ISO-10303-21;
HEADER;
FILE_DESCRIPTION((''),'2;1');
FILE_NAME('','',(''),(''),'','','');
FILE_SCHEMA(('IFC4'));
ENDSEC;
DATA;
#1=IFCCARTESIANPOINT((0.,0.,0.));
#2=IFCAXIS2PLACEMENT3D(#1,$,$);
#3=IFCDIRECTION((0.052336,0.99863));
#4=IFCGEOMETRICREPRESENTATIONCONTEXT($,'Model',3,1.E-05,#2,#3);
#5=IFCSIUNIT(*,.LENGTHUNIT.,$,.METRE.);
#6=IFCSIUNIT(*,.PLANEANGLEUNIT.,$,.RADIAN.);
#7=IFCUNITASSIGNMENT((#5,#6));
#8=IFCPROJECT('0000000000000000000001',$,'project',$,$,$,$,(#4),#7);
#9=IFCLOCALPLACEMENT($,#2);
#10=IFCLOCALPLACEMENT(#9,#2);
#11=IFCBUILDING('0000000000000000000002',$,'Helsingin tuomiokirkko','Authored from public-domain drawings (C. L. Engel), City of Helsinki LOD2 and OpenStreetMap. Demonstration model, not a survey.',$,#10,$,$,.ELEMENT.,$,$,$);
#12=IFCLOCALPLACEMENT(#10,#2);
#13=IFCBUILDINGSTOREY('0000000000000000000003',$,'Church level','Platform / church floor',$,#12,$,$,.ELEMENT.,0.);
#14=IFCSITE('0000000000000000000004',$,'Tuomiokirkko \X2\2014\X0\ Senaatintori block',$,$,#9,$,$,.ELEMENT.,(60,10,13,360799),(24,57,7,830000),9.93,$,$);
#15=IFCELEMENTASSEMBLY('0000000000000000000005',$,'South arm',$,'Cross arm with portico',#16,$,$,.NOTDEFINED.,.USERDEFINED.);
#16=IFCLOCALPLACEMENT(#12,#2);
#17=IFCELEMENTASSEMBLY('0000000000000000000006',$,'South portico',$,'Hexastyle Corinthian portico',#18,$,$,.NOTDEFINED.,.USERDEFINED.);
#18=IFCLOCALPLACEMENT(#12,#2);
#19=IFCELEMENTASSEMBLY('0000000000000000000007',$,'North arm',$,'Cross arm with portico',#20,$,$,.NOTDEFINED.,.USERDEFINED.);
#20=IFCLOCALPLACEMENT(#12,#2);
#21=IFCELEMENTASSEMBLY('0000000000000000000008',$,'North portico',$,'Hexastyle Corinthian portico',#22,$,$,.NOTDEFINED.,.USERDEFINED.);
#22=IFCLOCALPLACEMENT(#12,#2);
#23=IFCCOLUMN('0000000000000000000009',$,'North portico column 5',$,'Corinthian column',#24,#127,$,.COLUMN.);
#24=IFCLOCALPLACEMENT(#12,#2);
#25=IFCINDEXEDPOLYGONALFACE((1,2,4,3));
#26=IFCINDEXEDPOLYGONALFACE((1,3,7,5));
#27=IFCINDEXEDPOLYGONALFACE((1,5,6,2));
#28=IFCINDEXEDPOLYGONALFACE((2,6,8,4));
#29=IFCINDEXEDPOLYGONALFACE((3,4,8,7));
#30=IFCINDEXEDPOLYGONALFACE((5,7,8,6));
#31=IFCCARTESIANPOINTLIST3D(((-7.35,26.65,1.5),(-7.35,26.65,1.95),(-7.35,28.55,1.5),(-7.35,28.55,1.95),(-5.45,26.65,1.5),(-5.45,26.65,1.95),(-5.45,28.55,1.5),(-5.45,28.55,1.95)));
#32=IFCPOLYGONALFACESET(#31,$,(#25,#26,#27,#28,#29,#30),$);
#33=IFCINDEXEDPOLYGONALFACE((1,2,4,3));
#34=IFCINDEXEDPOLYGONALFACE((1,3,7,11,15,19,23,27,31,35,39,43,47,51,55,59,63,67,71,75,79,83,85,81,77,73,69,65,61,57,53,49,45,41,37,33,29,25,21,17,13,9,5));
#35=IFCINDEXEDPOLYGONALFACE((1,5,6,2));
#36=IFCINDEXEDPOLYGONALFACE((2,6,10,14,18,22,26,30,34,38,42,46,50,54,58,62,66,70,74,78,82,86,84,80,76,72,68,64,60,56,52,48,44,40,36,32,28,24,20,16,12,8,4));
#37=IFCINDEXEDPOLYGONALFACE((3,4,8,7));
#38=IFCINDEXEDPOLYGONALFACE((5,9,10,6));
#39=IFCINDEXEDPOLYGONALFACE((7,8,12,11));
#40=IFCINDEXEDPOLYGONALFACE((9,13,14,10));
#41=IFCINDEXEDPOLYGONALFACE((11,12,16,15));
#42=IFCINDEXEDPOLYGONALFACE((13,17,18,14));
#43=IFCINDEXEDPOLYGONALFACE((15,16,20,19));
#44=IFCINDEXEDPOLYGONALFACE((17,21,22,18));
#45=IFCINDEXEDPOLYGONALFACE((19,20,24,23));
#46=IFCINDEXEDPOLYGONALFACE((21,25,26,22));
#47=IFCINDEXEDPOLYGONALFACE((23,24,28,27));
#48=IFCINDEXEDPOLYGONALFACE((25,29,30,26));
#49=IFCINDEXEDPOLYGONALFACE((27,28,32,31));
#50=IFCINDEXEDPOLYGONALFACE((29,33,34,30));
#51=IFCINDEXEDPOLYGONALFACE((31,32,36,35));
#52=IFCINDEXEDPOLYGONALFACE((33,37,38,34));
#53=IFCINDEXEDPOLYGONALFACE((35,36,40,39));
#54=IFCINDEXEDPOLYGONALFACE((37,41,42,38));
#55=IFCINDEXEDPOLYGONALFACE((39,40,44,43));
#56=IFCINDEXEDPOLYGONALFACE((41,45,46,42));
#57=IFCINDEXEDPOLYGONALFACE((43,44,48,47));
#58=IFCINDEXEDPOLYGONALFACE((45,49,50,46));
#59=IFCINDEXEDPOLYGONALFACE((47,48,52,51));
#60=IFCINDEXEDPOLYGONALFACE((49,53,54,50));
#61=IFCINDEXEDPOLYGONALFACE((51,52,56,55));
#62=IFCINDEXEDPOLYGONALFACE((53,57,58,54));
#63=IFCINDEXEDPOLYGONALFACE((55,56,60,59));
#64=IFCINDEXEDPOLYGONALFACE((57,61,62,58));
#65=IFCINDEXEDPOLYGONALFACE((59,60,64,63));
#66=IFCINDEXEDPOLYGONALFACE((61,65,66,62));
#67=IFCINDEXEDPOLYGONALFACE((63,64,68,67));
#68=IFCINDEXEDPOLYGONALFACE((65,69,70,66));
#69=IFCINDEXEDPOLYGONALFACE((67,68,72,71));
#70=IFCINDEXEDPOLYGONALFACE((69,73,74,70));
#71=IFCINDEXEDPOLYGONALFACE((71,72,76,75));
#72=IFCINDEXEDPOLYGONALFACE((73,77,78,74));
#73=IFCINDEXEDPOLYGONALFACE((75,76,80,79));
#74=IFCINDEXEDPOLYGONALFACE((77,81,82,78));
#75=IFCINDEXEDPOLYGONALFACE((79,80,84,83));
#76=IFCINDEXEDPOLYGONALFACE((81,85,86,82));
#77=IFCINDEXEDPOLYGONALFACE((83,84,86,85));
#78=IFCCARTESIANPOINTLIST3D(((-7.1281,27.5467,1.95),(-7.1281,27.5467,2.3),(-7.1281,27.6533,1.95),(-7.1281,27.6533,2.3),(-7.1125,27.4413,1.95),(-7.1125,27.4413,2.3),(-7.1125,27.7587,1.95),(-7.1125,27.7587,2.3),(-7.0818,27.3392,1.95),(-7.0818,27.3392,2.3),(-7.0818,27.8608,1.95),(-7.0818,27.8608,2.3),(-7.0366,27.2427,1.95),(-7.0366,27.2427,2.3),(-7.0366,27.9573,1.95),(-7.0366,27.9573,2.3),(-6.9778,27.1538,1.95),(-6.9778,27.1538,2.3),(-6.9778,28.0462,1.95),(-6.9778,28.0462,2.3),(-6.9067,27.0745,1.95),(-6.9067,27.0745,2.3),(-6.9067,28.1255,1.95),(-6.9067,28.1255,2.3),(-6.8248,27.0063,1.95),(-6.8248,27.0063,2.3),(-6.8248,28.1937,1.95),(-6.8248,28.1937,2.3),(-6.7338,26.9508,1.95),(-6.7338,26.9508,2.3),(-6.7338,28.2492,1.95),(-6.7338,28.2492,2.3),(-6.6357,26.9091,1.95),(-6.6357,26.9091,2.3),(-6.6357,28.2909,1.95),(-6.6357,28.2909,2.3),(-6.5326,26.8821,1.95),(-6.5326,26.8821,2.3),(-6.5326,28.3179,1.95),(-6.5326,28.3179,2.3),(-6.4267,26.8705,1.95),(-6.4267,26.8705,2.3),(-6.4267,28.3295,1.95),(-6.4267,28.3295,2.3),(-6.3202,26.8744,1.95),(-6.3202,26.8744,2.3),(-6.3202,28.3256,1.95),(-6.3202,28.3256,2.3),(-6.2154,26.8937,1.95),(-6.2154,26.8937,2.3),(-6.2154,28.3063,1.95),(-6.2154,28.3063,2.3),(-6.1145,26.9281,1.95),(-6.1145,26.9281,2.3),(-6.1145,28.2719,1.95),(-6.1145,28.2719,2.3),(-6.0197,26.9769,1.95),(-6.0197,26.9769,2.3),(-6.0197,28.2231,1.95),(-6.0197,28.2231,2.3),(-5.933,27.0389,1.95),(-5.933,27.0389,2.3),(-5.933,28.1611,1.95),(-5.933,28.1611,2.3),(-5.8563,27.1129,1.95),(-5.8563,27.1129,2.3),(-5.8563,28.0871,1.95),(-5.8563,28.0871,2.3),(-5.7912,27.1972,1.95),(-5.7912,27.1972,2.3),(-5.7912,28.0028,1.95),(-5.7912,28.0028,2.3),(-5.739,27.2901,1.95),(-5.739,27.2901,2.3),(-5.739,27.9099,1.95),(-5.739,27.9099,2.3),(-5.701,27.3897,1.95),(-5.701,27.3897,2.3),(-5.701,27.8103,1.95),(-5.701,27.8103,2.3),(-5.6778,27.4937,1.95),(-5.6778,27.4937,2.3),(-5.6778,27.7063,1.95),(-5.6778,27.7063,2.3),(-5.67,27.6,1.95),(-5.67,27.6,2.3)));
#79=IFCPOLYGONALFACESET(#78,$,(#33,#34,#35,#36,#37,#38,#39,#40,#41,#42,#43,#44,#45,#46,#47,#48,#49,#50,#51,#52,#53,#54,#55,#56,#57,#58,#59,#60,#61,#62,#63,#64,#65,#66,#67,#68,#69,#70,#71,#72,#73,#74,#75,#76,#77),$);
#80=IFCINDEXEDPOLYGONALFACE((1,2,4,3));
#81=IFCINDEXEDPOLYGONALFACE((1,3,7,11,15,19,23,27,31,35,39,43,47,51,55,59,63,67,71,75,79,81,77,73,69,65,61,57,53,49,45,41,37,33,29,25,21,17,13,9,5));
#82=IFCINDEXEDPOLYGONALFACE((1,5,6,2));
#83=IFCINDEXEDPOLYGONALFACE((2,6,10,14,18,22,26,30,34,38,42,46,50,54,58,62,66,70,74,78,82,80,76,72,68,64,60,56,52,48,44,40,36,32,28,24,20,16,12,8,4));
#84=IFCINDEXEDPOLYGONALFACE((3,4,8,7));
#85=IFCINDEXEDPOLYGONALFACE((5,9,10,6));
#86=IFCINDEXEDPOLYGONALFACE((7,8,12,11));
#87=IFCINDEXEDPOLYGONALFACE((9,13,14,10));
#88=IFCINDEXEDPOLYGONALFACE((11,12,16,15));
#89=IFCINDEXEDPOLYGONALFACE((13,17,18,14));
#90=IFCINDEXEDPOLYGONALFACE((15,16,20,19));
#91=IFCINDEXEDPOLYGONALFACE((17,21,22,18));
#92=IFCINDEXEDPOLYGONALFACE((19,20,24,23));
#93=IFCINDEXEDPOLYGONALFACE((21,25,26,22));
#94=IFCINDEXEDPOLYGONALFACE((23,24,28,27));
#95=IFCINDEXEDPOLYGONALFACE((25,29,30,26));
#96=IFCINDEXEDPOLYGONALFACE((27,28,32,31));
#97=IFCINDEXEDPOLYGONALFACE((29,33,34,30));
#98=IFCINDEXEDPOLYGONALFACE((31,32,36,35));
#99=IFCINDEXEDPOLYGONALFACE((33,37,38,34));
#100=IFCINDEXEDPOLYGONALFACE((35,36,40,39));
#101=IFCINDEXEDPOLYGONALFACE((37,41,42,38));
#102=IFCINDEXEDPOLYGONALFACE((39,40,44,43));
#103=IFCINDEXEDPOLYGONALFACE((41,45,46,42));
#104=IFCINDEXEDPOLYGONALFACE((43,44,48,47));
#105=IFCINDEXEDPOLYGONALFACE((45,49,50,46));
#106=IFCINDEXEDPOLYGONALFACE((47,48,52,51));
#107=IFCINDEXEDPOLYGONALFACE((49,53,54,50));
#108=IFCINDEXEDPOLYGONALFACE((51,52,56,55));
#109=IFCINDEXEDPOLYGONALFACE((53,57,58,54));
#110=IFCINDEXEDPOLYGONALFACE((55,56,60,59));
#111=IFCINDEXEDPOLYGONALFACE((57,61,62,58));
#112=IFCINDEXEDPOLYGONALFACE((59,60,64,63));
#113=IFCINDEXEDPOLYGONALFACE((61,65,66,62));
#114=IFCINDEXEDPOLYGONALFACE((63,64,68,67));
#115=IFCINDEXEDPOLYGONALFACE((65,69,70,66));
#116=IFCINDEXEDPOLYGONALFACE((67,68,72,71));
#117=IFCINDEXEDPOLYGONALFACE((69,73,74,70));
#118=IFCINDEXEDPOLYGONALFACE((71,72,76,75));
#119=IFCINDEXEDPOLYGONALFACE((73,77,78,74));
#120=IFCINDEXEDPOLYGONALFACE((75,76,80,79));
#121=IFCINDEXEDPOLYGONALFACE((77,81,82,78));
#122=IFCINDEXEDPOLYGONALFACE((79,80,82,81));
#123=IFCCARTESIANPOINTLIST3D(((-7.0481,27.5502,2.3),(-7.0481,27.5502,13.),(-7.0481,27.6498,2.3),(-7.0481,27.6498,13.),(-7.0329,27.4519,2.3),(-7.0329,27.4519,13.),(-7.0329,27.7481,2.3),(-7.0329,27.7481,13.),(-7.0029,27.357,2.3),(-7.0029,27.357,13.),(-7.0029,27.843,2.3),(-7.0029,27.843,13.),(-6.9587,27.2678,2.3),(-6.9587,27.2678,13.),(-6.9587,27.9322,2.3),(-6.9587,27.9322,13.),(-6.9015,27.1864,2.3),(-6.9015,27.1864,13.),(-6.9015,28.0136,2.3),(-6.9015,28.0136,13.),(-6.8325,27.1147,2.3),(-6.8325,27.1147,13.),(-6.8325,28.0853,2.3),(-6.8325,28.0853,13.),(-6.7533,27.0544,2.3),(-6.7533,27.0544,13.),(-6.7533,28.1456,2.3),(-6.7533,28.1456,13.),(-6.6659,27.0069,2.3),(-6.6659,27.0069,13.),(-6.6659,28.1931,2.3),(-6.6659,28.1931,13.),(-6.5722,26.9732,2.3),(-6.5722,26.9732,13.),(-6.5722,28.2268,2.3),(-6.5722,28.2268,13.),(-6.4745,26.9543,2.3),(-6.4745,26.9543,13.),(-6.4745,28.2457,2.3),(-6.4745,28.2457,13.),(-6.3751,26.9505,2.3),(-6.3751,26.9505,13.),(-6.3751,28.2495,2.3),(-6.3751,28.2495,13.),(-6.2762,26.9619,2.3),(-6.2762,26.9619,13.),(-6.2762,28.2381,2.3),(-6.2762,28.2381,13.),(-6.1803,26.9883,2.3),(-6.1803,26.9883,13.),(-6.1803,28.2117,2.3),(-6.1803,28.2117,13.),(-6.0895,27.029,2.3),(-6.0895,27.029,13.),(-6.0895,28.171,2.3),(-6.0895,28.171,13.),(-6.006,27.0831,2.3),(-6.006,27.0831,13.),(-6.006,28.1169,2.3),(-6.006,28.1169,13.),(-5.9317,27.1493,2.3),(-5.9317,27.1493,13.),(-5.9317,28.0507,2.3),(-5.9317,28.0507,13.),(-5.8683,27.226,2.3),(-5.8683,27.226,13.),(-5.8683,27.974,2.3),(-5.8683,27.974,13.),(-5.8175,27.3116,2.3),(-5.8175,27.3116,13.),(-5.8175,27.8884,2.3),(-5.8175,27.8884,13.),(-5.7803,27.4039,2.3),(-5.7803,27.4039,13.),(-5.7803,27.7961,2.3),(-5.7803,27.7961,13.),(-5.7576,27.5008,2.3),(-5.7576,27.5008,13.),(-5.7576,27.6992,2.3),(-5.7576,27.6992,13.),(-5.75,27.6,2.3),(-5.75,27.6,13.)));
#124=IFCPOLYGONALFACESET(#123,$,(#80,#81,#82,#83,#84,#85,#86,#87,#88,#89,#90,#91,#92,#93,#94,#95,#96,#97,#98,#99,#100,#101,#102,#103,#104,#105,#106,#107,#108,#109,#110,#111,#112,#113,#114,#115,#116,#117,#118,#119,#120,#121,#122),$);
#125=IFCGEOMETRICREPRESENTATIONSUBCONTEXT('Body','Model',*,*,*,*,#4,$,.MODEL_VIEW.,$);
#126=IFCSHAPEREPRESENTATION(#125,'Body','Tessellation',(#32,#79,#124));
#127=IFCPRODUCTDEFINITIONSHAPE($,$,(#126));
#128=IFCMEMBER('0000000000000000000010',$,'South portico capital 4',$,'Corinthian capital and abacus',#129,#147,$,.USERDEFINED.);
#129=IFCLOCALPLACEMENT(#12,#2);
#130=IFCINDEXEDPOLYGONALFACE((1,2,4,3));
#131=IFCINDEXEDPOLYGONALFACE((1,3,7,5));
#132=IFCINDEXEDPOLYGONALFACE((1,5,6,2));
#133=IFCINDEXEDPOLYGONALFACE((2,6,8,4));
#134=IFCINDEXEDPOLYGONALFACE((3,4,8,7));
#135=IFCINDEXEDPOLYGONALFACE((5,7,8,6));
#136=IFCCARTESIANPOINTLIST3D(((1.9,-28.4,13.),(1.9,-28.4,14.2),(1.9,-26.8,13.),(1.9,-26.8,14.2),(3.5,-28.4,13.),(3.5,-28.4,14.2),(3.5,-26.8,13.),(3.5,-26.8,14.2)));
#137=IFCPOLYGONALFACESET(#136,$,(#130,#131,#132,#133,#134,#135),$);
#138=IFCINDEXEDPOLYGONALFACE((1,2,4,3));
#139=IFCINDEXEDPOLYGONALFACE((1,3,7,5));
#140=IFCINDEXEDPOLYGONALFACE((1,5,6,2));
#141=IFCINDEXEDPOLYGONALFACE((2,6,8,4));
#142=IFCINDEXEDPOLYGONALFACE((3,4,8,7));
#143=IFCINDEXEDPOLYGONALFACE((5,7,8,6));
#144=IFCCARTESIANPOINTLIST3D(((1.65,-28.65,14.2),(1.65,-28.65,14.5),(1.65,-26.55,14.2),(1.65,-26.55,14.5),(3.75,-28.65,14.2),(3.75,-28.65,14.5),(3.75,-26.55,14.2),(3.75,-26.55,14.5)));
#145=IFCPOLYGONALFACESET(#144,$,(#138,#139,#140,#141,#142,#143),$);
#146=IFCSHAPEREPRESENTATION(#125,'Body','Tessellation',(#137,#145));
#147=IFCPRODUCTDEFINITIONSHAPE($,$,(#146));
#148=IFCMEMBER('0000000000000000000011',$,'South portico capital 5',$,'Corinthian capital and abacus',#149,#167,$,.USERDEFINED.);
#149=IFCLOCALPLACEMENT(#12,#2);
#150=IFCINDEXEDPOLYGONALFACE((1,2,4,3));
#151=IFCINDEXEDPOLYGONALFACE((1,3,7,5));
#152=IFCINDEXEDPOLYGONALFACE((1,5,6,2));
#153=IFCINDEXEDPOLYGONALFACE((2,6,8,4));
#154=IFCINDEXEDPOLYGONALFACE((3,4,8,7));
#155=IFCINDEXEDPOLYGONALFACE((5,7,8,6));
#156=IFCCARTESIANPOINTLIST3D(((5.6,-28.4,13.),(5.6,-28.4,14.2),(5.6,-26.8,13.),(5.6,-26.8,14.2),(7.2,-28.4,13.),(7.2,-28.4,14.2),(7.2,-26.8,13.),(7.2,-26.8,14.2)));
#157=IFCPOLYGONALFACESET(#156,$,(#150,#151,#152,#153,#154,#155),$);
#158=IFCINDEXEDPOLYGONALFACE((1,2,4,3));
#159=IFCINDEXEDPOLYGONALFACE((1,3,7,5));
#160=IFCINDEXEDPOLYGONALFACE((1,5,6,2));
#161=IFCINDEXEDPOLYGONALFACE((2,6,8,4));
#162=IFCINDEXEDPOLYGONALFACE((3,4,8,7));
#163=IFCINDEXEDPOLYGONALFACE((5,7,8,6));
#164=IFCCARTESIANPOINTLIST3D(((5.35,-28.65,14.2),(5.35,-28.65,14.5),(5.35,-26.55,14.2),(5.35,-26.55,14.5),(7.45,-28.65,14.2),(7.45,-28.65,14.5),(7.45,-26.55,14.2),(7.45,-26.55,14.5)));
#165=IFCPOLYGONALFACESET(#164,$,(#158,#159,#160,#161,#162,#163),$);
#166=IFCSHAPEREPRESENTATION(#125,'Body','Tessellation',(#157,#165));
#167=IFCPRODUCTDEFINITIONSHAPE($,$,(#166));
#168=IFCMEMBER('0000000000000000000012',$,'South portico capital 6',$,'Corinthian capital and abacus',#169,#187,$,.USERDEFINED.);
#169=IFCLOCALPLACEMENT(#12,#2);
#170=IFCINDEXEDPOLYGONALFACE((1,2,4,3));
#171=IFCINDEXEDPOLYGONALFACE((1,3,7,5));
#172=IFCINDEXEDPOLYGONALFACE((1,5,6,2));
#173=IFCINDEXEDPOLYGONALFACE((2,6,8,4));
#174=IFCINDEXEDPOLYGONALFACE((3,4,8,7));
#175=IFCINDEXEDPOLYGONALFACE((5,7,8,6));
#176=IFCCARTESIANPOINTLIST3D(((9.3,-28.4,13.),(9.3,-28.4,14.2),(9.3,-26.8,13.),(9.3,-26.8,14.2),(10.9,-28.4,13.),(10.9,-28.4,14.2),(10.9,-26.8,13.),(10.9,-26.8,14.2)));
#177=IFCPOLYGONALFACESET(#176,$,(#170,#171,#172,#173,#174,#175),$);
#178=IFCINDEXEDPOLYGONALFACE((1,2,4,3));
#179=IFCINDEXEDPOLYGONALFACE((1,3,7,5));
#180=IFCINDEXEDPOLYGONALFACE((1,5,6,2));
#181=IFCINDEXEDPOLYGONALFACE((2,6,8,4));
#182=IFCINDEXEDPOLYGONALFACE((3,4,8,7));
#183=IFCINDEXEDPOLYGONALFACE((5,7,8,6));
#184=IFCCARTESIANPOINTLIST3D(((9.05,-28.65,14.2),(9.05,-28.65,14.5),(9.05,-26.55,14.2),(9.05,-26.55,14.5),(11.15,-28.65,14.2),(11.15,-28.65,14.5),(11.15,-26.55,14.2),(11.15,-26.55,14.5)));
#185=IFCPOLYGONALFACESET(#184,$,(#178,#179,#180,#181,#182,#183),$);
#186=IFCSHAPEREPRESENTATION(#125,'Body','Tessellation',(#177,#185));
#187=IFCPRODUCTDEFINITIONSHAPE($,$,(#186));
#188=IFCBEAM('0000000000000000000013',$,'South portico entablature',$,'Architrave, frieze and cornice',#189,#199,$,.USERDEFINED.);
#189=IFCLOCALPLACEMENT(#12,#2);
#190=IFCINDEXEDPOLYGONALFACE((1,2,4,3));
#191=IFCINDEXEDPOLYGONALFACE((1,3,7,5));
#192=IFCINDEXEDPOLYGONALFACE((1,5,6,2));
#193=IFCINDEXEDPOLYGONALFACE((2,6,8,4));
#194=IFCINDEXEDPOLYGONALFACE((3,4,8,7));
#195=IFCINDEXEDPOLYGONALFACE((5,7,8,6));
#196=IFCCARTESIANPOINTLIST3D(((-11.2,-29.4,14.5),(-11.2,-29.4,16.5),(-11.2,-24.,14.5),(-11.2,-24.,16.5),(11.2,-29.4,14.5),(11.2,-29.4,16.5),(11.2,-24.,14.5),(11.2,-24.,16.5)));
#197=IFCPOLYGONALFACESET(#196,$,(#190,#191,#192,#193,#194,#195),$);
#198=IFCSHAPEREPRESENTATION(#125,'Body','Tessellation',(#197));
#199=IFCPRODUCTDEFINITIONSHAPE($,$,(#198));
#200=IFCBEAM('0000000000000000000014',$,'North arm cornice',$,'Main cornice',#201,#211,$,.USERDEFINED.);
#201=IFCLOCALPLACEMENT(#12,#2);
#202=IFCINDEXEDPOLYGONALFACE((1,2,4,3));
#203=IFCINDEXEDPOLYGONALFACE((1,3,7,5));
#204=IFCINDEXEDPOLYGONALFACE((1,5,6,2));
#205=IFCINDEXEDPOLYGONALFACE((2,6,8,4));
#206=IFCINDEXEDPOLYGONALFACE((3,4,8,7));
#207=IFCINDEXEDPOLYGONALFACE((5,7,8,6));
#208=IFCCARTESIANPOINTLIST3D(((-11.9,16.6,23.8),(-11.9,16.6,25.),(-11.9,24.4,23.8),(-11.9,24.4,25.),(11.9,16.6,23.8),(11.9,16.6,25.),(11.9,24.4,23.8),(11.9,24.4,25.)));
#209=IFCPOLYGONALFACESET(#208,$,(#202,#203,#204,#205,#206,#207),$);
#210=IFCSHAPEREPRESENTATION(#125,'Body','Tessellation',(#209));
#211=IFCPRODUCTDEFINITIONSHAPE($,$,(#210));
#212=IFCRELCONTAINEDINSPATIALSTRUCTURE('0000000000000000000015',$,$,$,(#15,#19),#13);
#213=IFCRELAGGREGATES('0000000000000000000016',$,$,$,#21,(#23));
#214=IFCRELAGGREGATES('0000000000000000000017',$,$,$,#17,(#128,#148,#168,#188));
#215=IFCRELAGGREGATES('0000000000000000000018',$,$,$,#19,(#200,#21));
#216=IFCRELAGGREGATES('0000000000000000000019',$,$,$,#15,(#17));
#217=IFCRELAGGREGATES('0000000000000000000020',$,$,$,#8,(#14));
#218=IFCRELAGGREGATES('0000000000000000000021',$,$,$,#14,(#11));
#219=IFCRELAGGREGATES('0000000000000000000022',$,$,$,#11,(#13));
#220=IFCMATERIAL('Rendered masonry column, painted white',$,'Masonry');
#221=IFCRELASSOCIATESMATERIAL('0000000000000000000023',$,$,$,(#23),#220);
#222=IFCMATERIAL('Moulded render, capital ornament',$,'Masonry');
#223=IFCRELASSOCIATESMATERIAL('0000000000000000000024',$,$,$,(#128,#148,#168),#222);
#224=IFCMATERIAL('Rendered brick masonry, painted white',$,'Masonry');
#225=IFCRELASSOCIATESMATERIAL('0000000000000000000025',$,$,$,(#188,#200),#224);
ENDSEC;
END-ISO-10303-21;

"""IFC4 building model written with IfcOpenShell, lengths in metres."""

from ifc_helpers import new_model, si_unit, direction, frame, origin, origin_2d_with_axis, place, context, subcontext, project, spatial, rectangle, circle, extrude, material, element, aggregate, save


model = new_model("IFC4")

# Units and contexts
model_context = context("Model", 3, precision=1e-05, world=origin(), true_north=direction((0.052336, 0.99863)))
body_context = subcontext(model_context, "Body", "Model", "MODEL_VIEW")
ifc_project = project(units=[si_unit("LENGTHUNIT", "METRE"), si_unit("PLANEANGLEUNIT", "RADIAN")], contexts=[model_context])

# Site, building, storey
site_placement = place(None, origin())
site = spatial("IfcSite", under=ifc_project, at=site_placement, Name="Tuomiokirkko — Senaatintori block", CompositionType="ELEMENT", RefLatitude=(60, 10, 13, 360799), RefLongitude=(24, 57, 7, 830000), RefElevation=9.93)
building_placement = place(site_placement, origin())
building = spatial("IfcBuilding", under=site, at=building_placement, Name="Helsingin tuomiokirkko", Description="Authored from public-domain drawings (C. L. Engel), City of Helsinki LOD2 and OpenStreetMap. Demonstration model, not a survey.", CompositionType="ELEMENT")
storey_placement = place(building_placement, origin())
storey = spatial("IfcBuildingStorey", under=building, at=storey_placement, Name="Church level", Description="Platform / church floor", CompositionType="ELEMENT", Elevation=0.0)

# Element assemblies, column
assembly_1_placement = place(building_placement, origin())
assembly_1 = element("IfcElementAssembly", 1, at=assembly_1_placement, inside=storey, Name="South arm", ObjectType="Cross arm with portico", AssemblyPlace="NOTDEFINED", PredefinedType="USERDEFINED")
assembly_2_placement = place(building_placement, origin())
assembly_2 = element("IfcElementAssembly", 2, at=assembly_2_placement, Name="South portico", ObjectType="Hexastyle Corinthian portico", AssemblyPlace="NOTDEFINED", PredefinedType="USERDEFINED")
ifc_material_1 = material(Name="Rendered masonry column, painted white", Category="Masonry")
assembly_3_placement = place(building_placement, origin())
assembly_3 = element("IfcElementAssembly", 3, at=assembly_3_placement, inside=storey, Name="North arm", ObjectType="Cross arm with portico", AssemblyPlace="NOTDEFINED", PredefinedType="USERDEFINED")
ifc_material_2 = material(Name="Rendered brick masonry, painted white", Category="Masonry")
assembly_4_placement = place(building_placement, origin())
assembly_4 = element("IfcElementAssembly", 4, at=assembly_4_placement, Name="North portico", ObjectType="Hexastyle Corinthian portico", AssemblyPlace="NOTDEFINED", PredefinedType="USERDEFINED")
column_1_placement = place(building_placement, origin())
column_1 = element("IfcColumn", 5, at=column_1_placement, material=ifc_material_1, Name="North portico column 5", ObjectType="Corinthian column", PredefinedType="COLUMN", context=body_context, shape_type="SweptSolid", body=[
    extrude(rectangle(XDim=1.9, YDim=1.9, at=origin_2d_with_axis()), frame((-6.4, 27.6, 1.5)), (0.0, 0.0, 1.0), 0.45),
    extrude(circle(Radius=0.73, at=origin_2d_with_axis()), frame((-6.4, 27.6, 1.95)), (0.0, 0.0, 1.0), 0.35),
    extrude(circle(Radius=0.65, at=origin_2d_with_axis()), frame((-6.4, 27.6, 2.3)), (0.0, 0.0, 1.0), 10.7),
])

# Members
ifc_material_3 = material(Name="Moulded render, capital ornament", Category="Masonry")
member_1_placement = place(building_placement, origin())
member_1 = element("IfcMember", 6, at=member_1_placement, material=ifc_material_3, Name="South portico capital 4", ObjectType="Corinthian capital and abacus", PredefinedType="USERDEFINED", context=body_context, shape_type="SweptSolid", body=[
    extrude(rectangle(XDim=1.6, YDim=1.6, at=origin_2d_with_axis()), frame((2.7, -27.6, 13.0)), (0.0, 0.0, 1.0), 1.2),
    extrude(rectangle(XDim=2.1, YDim=2.1, at=origin_2d_with_axis()), frame((2.7, -27.6, 14.2)), (0.0, 0.0, 1.0), 0.3),
])
member_2_placement = place(building_placement, origin())
member_2 = element("IfcMember", 7, at=member_2_placement, material=ifc_material_3, Name="South portico capital 5", ObjectType="Corinthian capital and abacus", PredefinedType="USERDEFINED", context=body_context, shape_type="SweptSolid", body=[
    extrude(rectangle(XDim=1.6, YDim=1.6, at=origin_2d_with_axis()), frame((6.4, -27.6, 13.0)), (0.0, 0.0, 1.0), 1.2),
    extrude(rectangle(XDim=2.1, YDim=2.1, at=origin_2d_with_axis()), frame((6.4, -27.6, 14.2)), (0.0, 0.0, 1.0), 0.3),
])
member_3_placement = place(building_placement, origin())
member_3 = element("IfcMember", 8, at=member_3_placement, material=ifc_material_3, Name="South portico capital 6", ObjectType="Corinthian capital and abacus", PredefinedType="USERDEFINED", context=body_context, shape_type="SweptSolid", body=[
    extrude(rectangle(XDim=1.6, YDim=1.6, at=origin_2d_with_axis()), frame((10.1, -27.6, 13.0)), (0.0, 0.0, 1.0), 1.2),
    extrude(rectangle(XDim=2.1, YDim=2.1, at=origin_2d_with_axis()), frame((10.1, -27.6, 14.2)), (0.0, 0.0, 1.0), 0.3),
])

# Beams
beam_1_placement = place(building_placement, origin())
beam_1 = element("IfcBeam", 9, at=beam_1_placement, material=ifc_material_2, Name="South portico entablature", ObjectType="Architrave, frieze and cornice", PredefinedType="USERDEFINED", context=body_context, shape_type="SweptSolid", body=[
    extrude(rectangle(XDim=22.4, YDim=5.4, at=origin_2d_with_axis()), frame((0.0, -26.7, 14.5)), (0.0, 0.0, 1.0), 2.0),
])
beam_2_placement = place(building_placement, origin())
beam_2 = element("IfcBeam", 10, at=beam_2_placement, material=ifc_material_2, Name="North arm cornice", ObjectType="Main cornice", PredefinedType="USERDEFINED", context=body_context, shape_type="SweptSolid", body=[
    extrude(rectangle(XDim=23.8, YDim=7.8, at=origin_2d_with_axis()), frame((0.0, 20.5, 23.8)), (0.0, 0.0, 1.0), 1.2),
])

aggregate(assembly_4, [column_1])

aggregate(assembly_2, [member_1, member_2, member_3, beam_1])
aggregate(assembly_3, [beam_2, assembly_4])

aggregate(assembly_1, [assembly_2])

save(model, "model.ifc")
